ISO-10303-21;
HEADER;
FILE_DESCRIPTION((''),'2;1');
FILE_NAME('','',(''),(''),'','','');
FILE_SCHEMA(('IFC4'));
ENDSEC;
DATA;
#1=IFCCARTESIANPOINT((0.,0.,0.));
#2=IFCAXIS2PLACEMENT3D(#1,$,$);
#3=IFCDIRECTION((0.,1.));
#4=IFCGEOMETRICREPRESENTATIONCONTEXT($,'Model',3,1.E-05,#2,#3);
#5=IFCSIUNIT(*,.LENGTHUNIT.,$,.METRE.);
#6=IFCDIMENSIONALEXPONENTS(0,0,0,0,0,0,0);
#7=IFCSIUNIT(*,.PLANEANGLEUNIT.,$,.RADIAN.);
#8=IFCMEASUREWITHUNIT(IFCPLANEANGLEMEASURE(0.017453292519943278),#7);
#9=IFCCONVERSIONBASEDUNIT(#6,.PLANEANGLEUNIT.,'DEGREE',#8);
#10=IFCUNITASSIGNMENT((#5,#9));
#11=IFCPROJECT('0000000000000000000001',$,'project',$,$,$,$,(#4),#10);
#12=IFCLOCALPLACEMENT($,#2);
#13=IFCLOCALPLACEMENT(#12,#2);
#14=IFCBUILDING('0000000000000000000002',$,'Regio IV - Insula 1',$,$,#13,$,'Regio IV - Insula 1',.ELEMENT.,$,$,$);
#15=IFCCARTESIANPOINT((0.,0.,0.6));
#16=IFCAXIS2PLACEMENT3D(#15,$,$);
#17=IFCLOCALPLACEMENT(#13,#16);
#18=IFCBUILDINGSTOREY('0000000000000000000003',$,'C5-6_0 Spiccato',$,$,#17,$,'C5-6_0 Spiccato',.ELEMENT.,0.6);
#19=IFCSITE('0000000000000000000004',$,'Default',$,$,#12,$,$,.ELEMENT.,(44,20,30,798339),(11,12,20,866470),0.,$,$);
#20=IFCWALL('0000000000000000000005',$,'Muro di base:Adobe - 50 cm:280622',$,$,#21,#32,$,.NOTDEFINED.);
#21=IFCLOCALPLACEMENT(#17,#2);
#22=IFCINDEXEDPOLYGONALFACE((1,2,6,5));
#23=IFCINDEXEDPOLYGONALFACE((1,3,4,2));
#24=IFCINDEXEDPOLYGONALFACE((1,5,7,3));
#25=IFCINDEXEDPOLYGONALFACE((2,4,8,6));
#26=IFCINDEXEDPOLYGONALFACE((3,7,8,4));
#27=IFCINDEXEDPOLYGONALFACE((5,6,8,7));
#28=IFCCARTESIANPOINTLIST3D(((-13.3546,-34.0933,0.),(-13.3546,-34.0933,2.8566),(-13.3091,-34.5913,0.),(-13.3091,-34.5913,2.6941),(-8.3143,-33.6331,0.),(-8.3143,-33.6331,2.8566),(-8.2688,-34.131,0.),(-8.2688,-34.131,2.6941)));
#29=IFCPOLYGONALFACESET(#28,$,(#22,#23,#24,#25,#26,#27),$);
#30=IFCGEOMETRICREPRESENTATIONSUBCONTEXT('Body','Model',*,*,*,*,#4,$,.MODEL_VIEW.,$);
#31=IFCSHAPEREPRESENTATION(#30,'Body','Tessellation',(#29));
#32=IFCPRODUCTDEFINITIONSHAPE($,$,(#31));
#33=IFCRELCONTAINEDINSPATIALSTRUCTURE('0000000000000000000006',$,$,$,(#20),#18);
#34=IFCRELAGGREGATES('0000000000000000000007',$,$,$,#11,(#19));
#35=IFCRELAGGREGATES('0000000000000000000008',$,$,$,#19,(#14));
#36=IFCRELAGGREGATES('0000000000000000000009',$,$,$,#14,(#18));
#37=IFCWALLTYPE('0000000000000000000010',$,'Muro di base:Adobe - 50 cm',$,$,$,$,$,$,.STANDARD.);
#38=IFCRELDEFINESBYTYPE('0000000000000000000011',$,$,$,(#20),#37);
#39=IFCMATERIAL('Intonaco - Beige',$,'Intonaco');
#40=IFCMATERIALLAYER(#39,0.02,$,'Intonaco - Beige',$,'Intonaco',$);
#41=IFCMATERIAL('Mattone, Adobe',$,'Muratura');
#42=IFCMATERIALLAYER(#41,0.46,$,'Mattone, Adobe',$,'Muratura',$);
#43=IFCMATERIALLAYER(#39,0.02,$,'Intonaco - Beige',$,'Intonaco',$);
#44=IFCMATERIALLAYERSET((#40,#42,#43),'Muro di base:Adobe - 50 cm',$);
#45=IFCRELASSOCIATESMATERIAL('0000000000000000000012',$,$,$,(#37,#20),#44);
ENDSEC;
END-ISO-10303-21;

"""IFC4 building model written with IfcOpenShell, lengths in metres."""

from ifc_helpers import new_model, entity, si_unit, converted_unit, direction, frame, frame_2d, origin, place, context, subcontext, project, spatial, polyline, rectangle, extrude, clip, bounded_halfspace, material, layer, layer_set, layer_usage, type_object, element, save


model = new_model("IFC4")

# Units and contexts
model_context = context("Model", 3, precision=1e-05, world=origin(), true_north=direction((0.0, 1.0)))
body_context = subcontext(model_context, "Body", "Model", "MODEL_VIEW")
ifc_project = project(units=[si_unit("LENGTHUNIT", "METRE"), converted_unit("PLANEANGLEUNIT", "DEGREE", entity("IfcPlaneAngleMeasure", 0.017453292519943278), si_unit("PLANEANGLEUNIT", "RADIAN"), dimensions=[0, 0, 0, 0, 0, 0, 0])], contexts=[model_context])

# Site, building, storey
site_placement = place(None, origin())
site = spatial("IfcSite", under=ifc_project, at=site_placement, Name="Default", CompositionType="ELEMENT", RefLatitude=(44, 20, 30, 798339), RefLongitude=(11, 12, 20, 866470), RefElevation=0.0)
building_placement = place(site_placement, origin())
building = spatial("IfcBuilding", under=site, at=building_placement, Name="Regio IV - Insula 1", LongName="Regio IV - Insula 1", CompositionType="ELEMENT")
storey_placement = place(building_placement, frame((0.0, 0.0, 0.6)))
storey = spatial("IfcBuildingStorey", under=building, at=storey_placement, Name="C5-6_0 Spiccato", LongName="C5-6_0 Spiccato", CompositionType="ELEMENT", Elevation=0.6)

# Shared definitions
ifc_material_1 = material(Name="Intonaco - Beige", Category="Intonaco")
ifc_material_2 = material(Name="Mattone, Adobe", Category="Muratura")

# Shared definitions
ifc_layer_1 = layer(ifc_material_1, 0.02, Name="Intonaco - Beige", Category="Intonaco")
ifc_layer_2 = layer(ifc_material_2, 0.46, Name="Mattone, Adobe", Category="Muratura")
ifc_layer_3 = layer(ifc_material_1, 0.02, Name="Intonaco - Beige", Category="Intonaco")
ifc_layer_set_1 = layer_set([ifc_layer_1, ifc_layer_2, ifc_layer_3], Name="Muro di base:Adobe - 50 cm")
wall_type_1 = type_object("IfcWallType", Name="Muro di base:Adobe - 50 cm", PredefinedType="STANDARD", material=ifc_layer_set_1)

# Wall
ifc_layer_usage_1 = layer_usage(ifc_layer_set_1, "AXIS2", "NEGATIVE", 0.25)
wall_1_placement = place(storey_placement, frame((-8.2916, -33.882, 0.0), z_axis=(0.0, 0.0, 1.0), x_axis=(-0.995856, -0.090941, 0.0)))
element("IfcWall", 1, at=wall_1_placement, inside=storey, type_object=wall_type_1, material=ifc_layer_usage_1, Name="Muro di base:Adobe - 50 cm:280622", PredefinedType="NOTDEFINED", context=body_context, shape_type="Clipping", body=[
    clip(extrude(rectangle(XDim=5.0612, YDim=0.5, at=frame_2d((2.5306, 0.0), x_axis=(-1.0, 0.0))), origin(), (0.0, 0.0, 1.0), 2.8566), bounded_halfspace(frame((0.0, -0.25, 2.8566), z_axis=(0.0, 0.309017, 0.951057), x_axis=(-1.0, 0.0, 0.0)), False, frame((0.0, -0.25, 2.8566)), polyline([(0.0, 0.0), (4.5612, 0.0), (5.0612, 0.0), (5.0612, 0.5), (0.0, 0.5), (0.0, 0.0)]))),
])

save(model, "model.ifc")
